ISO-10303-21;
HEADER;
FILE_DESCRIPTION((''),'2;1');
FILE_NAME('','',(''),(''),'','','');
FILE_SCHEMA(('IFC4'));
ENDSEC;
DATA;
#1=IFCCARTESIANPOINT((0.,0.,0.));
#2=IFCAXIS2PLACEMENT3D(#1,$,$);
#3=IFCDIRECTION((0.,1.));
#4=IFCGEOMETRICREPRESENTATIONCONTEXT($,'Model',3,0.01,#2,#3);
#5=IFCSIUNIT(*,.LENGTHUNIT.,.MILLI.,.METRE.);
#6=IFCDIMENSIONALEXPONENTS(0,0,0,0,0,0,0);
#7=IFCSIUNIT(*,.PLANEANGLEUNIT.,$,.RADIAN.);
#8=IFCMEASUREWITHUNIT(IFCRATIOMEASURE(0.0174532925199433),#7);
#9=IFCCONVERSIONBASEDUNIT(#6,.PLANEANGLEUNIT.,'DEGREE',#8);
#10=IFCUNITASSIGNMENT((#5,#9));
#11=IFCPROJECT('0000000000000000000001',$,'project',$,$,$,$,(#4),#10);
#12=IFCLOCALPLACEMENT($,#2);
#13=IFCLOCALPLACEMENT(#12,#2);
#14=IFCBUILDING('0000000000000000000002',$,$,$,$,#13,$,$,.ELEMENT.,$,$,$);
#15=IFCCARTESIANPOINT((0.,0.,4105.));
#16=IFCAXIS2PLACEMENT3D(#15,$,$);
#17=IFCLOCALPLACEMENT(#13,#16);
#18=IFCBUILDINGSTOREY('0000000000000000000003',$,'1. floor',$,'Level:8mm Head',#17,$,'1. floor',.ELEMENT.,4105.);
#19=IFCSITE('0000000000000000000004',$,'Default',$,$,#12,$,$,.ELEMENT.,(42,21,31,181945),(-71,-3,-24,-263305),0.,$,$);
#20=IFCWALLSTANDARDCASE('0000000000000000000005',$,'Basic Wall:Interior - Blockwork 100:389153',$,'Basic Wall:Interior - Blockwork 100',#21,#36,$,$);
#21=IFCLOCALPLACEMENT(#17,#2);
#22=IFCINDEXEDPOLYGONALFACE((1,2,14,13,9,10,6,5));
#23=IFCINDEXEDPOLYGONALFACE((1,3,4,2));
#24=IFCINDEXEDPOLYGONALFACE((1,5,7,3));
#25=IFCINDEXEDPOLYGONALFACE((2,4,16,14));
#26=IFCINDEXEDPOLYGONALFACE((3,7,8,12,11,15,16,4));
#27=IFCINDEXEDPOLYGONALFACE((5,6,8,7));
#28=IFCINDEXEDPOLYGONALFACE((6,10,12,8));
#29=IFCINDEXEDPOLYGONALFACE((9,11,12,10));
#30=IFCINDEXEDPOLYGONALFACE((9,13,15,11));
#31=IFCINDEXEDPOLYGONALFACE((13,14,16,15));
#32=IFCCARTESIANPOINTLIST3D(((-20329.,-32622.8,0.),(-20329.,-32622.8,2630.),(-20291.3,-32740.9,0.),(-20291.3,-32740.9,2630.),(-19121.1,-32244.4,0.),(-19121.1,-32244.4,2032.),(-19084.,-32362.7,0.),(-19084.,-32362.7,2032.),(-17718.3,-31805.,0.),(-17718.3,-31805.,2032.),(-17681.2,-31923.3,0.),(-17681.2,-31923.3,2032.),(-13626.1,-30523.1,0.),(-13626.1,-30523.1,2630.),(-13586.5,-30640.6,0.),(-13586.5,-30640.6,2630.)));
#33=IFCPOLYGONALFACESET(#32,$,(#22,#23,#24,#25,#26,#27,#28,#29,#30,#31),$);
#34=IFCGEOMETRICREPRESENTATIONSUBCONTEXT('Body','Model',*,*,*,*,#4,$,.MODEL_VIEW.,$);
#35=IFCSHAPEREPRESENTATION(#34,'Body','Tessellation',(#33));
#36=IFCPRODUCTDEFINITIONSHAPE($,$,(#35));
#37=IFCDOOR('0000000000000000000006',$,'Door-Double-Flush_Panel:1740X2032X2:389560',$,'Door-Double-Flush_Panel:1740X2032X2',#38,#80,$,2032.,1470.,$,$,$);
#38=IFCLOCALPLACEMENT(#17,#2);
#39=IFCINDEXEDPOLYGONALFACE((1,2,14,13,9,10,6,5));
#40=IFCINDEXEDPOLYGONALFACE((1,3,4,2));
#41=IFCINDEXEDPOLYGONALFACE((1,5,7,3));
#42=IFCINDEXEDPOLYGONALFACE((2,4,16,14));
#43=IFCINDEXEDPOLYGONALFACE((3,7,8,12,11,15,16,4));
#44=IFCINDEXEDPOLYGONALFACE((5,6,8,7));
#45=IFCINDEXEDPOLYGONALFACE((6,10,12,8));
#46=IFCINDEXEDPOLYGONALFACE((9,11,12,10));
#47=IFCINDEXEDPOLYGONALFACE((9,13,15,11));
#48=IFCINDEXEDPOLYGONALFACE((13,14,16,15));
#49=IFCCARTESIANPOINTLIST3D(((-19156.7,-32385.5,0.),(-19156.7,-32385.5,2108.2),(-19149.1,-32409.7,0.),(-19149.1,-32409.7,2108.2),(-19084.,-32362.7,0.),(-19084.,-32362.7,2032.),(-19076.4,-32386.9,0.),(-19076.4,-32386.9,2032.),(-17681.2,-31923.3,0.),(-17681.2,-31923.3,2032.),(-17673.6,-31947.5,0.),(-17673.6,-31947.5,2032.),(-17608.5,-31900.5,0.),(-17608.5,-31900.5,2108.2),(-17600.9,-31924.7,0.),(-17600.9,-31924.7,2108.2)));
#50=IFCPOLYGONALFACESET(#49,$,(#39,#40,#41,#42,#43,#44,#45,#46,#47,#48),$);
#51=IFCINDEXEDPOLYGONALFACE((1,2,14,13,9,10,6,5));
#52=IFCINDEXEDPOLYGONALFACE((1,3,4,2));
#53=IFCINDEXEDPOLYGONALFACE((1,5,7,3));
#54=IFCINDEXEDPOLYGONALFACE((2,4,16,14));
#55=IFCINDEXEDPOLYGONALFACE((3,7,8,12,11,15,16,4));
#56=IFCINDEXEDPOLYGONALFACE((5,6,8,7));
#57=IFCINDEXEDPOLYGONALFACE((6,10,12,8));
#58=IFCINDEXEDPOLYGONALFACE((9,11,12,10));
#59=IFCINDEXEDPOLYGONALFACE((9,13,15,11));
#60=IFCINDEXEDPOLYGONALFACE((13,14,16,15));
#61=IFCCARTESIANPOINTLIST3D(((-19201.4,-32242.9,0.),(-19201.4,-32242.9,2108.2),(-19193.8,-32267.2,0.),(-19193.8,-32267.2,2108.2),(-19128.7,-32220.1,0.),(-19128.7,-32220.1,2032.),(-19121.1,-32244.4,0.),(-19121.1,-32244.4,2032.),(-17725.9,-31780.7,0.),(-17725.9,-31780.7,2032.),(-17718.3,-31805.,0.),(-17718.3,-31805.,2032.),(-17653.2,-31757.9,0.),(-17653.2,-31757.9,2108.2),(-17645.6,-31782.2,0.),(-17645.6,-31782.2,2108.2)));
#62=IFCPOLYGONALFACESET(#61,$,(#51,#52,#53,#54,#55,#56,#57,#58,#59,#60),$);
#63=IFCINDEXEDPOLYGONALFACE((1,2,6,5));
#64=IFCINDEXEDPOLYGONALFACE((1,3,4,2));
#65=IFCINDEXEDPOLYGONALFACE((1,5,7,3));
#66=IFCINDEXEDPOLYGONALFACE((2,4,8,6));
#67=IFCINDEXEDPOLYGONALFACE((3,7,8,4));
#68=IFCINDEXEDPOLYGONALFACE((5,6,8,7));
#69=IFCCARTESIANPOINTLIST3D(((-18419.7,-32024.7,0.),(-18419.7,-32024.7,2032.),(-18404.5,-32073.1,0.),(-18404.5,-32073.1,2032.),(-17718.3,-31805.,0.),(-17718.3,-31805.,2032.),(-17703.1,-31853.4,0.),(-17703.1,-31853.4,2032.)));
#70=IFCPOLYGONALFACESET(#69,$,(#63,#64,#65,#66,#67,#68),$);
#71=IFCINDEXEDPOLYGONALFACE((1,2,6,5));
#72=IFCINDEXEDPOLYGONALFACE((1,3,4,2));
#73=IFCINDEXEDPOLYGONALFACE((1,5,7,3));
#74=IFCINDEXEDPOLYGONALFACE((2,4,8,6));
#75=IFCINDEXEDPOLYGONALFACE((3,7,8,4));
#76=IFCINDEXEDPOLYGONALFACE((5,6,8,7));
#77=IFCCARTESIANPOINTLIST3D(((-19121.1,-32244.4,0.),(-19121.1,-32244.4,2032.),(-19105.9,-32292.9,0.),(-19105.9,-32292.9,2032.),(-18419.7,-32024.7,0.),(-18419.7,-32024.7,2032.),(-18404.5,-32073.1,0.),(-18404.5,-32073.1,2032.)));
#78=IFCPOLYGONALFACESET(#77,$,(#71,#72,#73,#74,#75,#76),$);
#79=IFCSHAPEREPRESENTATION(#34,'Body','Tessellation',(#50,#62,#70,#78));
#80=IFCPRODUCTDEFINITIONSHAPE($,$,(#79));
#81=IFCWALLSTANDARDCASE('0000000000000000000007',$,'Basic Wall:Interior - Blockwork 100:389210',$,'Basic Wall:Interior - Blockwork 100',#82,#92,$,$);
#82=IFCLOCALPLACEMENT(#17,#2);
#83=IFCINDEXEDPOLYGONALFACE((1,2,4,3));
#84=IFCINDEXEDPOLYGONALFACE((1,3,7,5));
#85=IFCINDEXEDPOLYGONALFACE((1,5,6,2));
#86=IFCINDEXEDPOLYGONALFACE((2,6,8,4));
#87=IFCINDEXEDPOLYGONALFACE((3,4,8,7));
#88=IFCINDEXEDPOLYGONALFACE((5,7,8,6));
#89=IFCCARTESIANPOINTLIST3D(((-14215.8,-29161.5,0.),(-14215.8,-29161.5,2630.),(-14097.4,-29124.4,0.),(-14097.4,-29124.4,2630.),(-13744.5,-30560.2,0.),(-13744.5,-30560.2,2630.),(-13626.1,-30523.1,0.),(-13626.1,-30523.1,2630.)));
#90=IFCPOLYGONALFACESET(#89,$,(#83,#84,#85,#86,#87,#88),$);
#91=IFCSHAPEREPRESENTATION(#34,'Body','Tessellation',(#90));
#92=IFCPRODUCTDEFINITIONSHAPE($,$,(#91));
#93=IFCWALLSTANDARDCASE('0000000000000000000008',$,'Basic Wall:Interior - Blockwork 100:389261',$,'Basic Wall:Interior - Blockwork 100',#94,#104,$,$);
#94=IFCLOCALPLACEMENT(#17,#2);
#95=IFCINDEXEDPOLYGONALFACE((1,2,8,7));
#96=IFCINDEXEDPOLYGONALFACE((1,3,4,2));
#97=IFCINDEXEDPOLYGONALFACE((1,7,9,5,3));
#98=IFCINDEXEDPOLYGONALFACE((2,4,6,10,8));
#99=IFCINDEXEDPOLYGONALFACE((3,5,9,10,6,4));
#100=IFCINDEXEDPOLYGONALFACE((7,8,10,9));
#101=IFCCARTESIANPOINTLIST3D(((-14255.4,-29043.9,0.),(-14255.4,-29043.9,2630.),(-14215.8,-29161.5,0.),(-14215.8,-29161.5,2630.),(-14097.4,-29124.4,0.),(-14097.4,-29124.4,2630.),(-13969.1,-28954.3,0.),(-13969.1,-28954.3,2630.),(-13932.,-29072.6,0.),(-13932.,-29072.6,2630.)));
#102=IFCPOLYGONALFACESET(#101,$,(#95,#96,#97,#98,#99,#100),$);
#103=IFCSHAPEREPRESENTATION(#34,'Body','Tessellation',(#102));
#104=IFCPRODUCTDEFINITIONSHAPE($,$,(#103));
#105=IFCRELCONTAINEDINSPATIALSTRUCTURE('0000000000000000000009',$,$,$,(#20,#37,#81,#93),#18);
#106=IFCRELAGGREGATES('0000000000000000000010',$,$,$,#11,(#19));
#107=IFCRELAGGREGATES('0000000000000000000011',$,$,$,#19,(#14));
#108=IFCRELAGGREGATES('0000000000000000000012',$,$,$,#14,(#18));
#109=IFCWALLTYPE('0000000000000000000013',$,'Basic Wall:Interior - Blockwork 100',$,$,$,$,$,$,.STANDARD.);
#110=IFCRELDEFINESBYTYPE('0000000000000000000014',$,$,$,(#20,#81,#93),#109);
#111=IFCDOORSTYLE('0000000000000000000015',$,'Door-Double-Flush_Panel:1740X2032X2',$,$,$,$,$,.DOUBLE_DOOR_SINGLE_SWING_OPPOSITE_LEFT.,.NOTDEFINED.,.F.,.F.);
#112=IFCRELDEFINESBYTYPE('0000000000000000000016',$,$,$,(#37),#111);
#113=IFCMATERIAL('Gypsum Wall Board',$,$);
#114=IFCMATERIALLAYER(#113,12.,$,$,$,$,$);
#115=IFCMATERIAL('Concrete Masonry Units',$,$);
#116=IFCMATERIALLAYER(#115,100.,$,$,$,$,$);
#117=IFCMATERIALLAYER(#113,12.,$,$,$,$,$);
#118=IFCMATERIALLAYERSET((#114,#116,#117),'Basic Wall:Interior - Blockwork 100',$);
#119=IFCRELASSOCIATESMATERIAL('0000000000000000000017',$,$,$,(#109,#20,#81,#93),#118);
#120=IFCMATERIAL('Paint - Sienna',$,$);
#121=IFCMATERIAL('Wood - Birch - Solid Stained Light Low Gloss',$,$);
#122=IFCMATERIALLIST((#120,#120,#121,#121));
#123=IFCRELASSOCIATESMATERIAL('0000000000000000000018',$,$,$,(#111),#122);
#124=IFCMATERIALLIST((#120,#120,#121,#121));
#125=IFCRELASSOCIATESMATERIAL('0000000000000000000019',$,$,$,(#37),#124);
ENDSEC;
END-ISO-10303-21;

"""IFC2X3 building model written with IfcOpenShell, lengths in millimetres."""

from ifc_helpers import new_model, entity, si_unit, converted_unit, direction, frame, frame_2d, origin, origin_2d_with_axis, place, context, subcontext, project, spatial, polyline, rectangle, outline, extrude, source, transform, mapped, material, material_list, layer, layer_set, layer_usage, type_object, type_shapes, element, fill, save


model = new_model("IFC2X3")

# Units and contexts
model_context = context("Model", 3, precision=0.01, world=origin(), true_north=direction((0.0, 1.0)))
body_context = subcontext(model_context, "Body", "Model", "MODEL_VIEW")
ifc_project = project(units=[si_unit("LENGTHUNIT", "METRE", prefix="MILLI"), converted_unit("PLANEANGLEUNIT", "DEGREE", entity("IfcRatioMeasure", 0.0174532925199433), si_unit("PLANEANGLEUNIT", "RADIAN"), dimensions=[0, 0, 0, 0, 0, 0, 0])], contexts=[model_context])

# Site, building, storey
site_placement = place(None, origin())
site = spatial("IfcSite", under=ifc_project, at=site_placement, Name="Default", CompositionType="ELEMENT", RefLatitude=(42, 21, 31, 181945), RefLongitude=(-71, -3, -24, -263305), RefElevation=0.0)
building_placement = place(site_placement, origin())
building = spatial("IfcBuilding", under=site, at=building_placement, CompositionType="ELEMENT")
storey_placement = place(building_placement, frame((0.0, 0.0, 4105.0)))
storey = spatial("IfcBuildingStorey", under=building, at=storey_placement, Name="1. floor", ObjectType="Level:8mm Head", LongName="1. floor", CompositionType="ELEMENT", Elevation=4105.0)

# Shared definitions
ifc_material_1 = material(Name="Gypsum Wall Board")
ifc_material_2 = material(Name="Paint - Sienna")
ifc_material_3 = material(Name="Wood - Birch - Solid Stained Light Low Gloss")

# Shared definitions
ifc_layer_1 = layer(ifc_material_1, 12.0)
ifc_material_4 = material(Name="Concrete Masonry Units")
ifc_layer_2 = layer(ifc_material_4, 100.0)
ifc_layer_3 = layer(ifc_material_1, 12.0)
ifc_layer_set_1 = layer_set([ifc_layer_1, ifc_layer_2, ifc_layer_3], Name="Basic Wall:Interior - Blockwork 100")
wall_type_1 = type_object("IfcWallType", Name="Basic Wall:Interior - Blockwork 100", PredefinedType="STANDARD", material=ifc_layer_set_1)

# Wall, opening, door
ifc_layer_usage_1 = layer_usage(ifc_layer_set_1, "AXIS2", "NEGATIVE", 62.0)
wall_1_placement = place(storey_placement, frame((-20310.5, -32681.9, 0.0), z_axis=(0.0, 0.0, 1.0), x_axis=(0.954277, 0.298924, 0.0)))
wall_1 = element("IfcWallStandardCase", 1, at=wall_1_placement, inside=storey, type_object=wall_type_1, material=ifc_layer_usage_1, Name="Basic Wall:Interior - Blockwork 100:389153", ObjectType="Basic Wall:Interior - Blockwork 100", context=body_context, shape_type="SweptSolid", body=[
    extrude(outline(polyline([(0.6, -62.0), (7026.7, -62.0), (7024.0, 62.0), (6900.0, 62.0), (0.0, 62.0), (0.6, -62.0)])), origin(), (0.0, 0.0, 1.0), 2630.0),
])
opening_1_placement = place(wall_1_placement, frame((1265.8, -62.0, 0.0)))
opening_1 = element("IfcOpeningElement", 2, at=opening_1_placement, cuts=wall_1, ObjectType="Opening", context=body_context, shape_type="SweptSolid", body=[
    extrude(rectangle(XDim=2032.0, YDim=1470.0, at=frame_2d((1016.0, 735.0), x_axis=(1.0, 0.0))), frame((0.0, 0.0, 0.0), z_axis=(0.0, 1.0, 0.0), x_axis=(0.0, 0.0, 1.0)), (0.0, 0.0, 1.0), 124.0),
])
ifc_material_list_1 = material_list([ifc_material_2, ifc_material_2, ifc_material_3, ifc_material_3])
ifc_material_list_2 = material_list([ifc_material_2, ifc_material_2, ifc_material_3, ifc_material_3])
door_style_1 = type_object("IfcDoorStyle", Name="Door-Double-Flush_Panel:1740X2032X2", ConstructionType="NOTDEFINED", OperationType="DOUBLE_DOOR_SINGLE_SWING_OPPOSITE_LEFT", ParameterTakesPrecedence=False, Sizeable=False, material=ifc_material_list_2)
shared_shape_1 = source(origin(), body_context, "Body", "SweptSolid", [
    extrude(outline(polyline([(-997.0, 735.0), (1035.0, 735.0), (1035.0, 811.2), (-1073.2, 811.2), (-1073.2, -811.2), (1035.0, -811.2), (1035.0, -735.0), (-997.0, -735.0), (-997.0, 735.0)])), frame((735.0, -25.4, 1035.0), z_axis=(0.0, 1.0, 0.0), x_axis=(0.0, 0.0, -1.0)), (0.0, 0.0, 1.0), 25.4),
    extrude(outline(polyline([(-997.0, 735.0), (1035.0, 735.0), (1035.0, 811.2), (-1073.2, 811.2), (-1073.2, -811.2), (1035.0, -811.2), (1035.0, -735.0), (-997.0, -735.0), (-997.0, 735.0)])), frame((735.0, 124.0, 1035.0), z_axis=(0.0, 1.0, 0.0), x_axis=(0.0, 0.0, -1.0)), (0.0, 0.0, 1.0), 25.4),
    extrude(rectangle(XDim=50.8, YDim=735.0, at=frame_2d((0.0, 0.0), x_axis=(1.0, 0.0))), frame((1102.5, 98.6, 0.0), z_axis=(0.0, 0.0, 1.0), x_axis=(0.0, -1.0, 0.0)), (0.0, 0.0, 1.0), 2032.0),
    extrude(rectangle(XDim=50.8, YDim=735.0, at=origin_2d_with_axis()), frame((367.5, 98.6, 0.0), z_axis=(0.0, 0.0, 1.0), x_axis=(0.0, -1.0, 0.0)), (0.0, 0.0, 1.0), 2032.0),
])
type_shapes(door_style_1, [shared_shape_1])
door_1_placement = place(opening_1_placement, origin())
door_1 = element("IfcDoor", 3, at=door_1_placement, inside=storey, type_object=door_style_1, material=ifc_material_list_1, Name="Door-Double-Flush_Panel:1740X2032X2:389560", ObjectType="Door-Double-Flush_Panel:1740X2032X2", OverallHeight=2032.0, OverallWidth=1470.0, context=body_context, shape_type="MappedRepresentation", body=[
    mapped(shared_shape_1, transform((0.0, 0.0, 0.0), scale=1.0)),
])
fill(opening_1, door_1)

# Walls
ifc_layer_usage_2 = layer_usage(ifc_layer_set_1, "AXIS2", "NEGATIVE", 62.0)
wall_2_placement = place(storey_placement, frame((-13684.9, -30542.9, 0.0), z_axis=(0.0, 0.0, 1.0), x_axis=(-0.319293, 0.947656, 0.0)))
element("IfcWallStandardCase", 4, at=wall_2_placement, inside=storey, type_object=wall_type_1, material=ifc_layer_usage_2, Name="Basic Wall:Interior - Blockwork 100:389210", ObjectType="Basic Wall:Interior - Blockwork 100", context=body_context, shape_type="SweptSolid", body=[
    extrude(outline(polyline([(1476.0, -62.0), (1478.6, 62.0), (2.7, 62.0), (0.0, -62.0), (1476.0, -62.0)])), origin(), (0.0, 0.0, 1.0), 2630.0),
])
ifc_layer_usage_3 = layer_usage(ifc_layer_set_1, "AXIS2", "NEGATIVE", 62.0)
wall_3_placement = place(storey_placement, frame((-14236.8, -29103.1, 0.0), z_axis=(0.0, 0.0, 1.0), x_axis=(0.954277, 0.298924, 0.0)))
element("IfcWallStandardCase", 5, at=wall_3_placement, inside=storey, type_object=wall_type_1, material=ifc_layer_usage_3, Name="Basic Wall:Interior - Blockwork 100:389261", ObjectType="Basic Wall:Interior - Blockwork 100", context=body_context, shape_type="SweptSolid", body=[
    extrude(outline(polyline([(300.0, -62.0), (300.0, 62.0), (0.0, 62.0), (2.7, -62.0), (126.7, -62.0), (300.0, -62.0)])), origin(), (0.0, 0.0, 1.0), 2630.0),
])

save(model, "model.ifc")
